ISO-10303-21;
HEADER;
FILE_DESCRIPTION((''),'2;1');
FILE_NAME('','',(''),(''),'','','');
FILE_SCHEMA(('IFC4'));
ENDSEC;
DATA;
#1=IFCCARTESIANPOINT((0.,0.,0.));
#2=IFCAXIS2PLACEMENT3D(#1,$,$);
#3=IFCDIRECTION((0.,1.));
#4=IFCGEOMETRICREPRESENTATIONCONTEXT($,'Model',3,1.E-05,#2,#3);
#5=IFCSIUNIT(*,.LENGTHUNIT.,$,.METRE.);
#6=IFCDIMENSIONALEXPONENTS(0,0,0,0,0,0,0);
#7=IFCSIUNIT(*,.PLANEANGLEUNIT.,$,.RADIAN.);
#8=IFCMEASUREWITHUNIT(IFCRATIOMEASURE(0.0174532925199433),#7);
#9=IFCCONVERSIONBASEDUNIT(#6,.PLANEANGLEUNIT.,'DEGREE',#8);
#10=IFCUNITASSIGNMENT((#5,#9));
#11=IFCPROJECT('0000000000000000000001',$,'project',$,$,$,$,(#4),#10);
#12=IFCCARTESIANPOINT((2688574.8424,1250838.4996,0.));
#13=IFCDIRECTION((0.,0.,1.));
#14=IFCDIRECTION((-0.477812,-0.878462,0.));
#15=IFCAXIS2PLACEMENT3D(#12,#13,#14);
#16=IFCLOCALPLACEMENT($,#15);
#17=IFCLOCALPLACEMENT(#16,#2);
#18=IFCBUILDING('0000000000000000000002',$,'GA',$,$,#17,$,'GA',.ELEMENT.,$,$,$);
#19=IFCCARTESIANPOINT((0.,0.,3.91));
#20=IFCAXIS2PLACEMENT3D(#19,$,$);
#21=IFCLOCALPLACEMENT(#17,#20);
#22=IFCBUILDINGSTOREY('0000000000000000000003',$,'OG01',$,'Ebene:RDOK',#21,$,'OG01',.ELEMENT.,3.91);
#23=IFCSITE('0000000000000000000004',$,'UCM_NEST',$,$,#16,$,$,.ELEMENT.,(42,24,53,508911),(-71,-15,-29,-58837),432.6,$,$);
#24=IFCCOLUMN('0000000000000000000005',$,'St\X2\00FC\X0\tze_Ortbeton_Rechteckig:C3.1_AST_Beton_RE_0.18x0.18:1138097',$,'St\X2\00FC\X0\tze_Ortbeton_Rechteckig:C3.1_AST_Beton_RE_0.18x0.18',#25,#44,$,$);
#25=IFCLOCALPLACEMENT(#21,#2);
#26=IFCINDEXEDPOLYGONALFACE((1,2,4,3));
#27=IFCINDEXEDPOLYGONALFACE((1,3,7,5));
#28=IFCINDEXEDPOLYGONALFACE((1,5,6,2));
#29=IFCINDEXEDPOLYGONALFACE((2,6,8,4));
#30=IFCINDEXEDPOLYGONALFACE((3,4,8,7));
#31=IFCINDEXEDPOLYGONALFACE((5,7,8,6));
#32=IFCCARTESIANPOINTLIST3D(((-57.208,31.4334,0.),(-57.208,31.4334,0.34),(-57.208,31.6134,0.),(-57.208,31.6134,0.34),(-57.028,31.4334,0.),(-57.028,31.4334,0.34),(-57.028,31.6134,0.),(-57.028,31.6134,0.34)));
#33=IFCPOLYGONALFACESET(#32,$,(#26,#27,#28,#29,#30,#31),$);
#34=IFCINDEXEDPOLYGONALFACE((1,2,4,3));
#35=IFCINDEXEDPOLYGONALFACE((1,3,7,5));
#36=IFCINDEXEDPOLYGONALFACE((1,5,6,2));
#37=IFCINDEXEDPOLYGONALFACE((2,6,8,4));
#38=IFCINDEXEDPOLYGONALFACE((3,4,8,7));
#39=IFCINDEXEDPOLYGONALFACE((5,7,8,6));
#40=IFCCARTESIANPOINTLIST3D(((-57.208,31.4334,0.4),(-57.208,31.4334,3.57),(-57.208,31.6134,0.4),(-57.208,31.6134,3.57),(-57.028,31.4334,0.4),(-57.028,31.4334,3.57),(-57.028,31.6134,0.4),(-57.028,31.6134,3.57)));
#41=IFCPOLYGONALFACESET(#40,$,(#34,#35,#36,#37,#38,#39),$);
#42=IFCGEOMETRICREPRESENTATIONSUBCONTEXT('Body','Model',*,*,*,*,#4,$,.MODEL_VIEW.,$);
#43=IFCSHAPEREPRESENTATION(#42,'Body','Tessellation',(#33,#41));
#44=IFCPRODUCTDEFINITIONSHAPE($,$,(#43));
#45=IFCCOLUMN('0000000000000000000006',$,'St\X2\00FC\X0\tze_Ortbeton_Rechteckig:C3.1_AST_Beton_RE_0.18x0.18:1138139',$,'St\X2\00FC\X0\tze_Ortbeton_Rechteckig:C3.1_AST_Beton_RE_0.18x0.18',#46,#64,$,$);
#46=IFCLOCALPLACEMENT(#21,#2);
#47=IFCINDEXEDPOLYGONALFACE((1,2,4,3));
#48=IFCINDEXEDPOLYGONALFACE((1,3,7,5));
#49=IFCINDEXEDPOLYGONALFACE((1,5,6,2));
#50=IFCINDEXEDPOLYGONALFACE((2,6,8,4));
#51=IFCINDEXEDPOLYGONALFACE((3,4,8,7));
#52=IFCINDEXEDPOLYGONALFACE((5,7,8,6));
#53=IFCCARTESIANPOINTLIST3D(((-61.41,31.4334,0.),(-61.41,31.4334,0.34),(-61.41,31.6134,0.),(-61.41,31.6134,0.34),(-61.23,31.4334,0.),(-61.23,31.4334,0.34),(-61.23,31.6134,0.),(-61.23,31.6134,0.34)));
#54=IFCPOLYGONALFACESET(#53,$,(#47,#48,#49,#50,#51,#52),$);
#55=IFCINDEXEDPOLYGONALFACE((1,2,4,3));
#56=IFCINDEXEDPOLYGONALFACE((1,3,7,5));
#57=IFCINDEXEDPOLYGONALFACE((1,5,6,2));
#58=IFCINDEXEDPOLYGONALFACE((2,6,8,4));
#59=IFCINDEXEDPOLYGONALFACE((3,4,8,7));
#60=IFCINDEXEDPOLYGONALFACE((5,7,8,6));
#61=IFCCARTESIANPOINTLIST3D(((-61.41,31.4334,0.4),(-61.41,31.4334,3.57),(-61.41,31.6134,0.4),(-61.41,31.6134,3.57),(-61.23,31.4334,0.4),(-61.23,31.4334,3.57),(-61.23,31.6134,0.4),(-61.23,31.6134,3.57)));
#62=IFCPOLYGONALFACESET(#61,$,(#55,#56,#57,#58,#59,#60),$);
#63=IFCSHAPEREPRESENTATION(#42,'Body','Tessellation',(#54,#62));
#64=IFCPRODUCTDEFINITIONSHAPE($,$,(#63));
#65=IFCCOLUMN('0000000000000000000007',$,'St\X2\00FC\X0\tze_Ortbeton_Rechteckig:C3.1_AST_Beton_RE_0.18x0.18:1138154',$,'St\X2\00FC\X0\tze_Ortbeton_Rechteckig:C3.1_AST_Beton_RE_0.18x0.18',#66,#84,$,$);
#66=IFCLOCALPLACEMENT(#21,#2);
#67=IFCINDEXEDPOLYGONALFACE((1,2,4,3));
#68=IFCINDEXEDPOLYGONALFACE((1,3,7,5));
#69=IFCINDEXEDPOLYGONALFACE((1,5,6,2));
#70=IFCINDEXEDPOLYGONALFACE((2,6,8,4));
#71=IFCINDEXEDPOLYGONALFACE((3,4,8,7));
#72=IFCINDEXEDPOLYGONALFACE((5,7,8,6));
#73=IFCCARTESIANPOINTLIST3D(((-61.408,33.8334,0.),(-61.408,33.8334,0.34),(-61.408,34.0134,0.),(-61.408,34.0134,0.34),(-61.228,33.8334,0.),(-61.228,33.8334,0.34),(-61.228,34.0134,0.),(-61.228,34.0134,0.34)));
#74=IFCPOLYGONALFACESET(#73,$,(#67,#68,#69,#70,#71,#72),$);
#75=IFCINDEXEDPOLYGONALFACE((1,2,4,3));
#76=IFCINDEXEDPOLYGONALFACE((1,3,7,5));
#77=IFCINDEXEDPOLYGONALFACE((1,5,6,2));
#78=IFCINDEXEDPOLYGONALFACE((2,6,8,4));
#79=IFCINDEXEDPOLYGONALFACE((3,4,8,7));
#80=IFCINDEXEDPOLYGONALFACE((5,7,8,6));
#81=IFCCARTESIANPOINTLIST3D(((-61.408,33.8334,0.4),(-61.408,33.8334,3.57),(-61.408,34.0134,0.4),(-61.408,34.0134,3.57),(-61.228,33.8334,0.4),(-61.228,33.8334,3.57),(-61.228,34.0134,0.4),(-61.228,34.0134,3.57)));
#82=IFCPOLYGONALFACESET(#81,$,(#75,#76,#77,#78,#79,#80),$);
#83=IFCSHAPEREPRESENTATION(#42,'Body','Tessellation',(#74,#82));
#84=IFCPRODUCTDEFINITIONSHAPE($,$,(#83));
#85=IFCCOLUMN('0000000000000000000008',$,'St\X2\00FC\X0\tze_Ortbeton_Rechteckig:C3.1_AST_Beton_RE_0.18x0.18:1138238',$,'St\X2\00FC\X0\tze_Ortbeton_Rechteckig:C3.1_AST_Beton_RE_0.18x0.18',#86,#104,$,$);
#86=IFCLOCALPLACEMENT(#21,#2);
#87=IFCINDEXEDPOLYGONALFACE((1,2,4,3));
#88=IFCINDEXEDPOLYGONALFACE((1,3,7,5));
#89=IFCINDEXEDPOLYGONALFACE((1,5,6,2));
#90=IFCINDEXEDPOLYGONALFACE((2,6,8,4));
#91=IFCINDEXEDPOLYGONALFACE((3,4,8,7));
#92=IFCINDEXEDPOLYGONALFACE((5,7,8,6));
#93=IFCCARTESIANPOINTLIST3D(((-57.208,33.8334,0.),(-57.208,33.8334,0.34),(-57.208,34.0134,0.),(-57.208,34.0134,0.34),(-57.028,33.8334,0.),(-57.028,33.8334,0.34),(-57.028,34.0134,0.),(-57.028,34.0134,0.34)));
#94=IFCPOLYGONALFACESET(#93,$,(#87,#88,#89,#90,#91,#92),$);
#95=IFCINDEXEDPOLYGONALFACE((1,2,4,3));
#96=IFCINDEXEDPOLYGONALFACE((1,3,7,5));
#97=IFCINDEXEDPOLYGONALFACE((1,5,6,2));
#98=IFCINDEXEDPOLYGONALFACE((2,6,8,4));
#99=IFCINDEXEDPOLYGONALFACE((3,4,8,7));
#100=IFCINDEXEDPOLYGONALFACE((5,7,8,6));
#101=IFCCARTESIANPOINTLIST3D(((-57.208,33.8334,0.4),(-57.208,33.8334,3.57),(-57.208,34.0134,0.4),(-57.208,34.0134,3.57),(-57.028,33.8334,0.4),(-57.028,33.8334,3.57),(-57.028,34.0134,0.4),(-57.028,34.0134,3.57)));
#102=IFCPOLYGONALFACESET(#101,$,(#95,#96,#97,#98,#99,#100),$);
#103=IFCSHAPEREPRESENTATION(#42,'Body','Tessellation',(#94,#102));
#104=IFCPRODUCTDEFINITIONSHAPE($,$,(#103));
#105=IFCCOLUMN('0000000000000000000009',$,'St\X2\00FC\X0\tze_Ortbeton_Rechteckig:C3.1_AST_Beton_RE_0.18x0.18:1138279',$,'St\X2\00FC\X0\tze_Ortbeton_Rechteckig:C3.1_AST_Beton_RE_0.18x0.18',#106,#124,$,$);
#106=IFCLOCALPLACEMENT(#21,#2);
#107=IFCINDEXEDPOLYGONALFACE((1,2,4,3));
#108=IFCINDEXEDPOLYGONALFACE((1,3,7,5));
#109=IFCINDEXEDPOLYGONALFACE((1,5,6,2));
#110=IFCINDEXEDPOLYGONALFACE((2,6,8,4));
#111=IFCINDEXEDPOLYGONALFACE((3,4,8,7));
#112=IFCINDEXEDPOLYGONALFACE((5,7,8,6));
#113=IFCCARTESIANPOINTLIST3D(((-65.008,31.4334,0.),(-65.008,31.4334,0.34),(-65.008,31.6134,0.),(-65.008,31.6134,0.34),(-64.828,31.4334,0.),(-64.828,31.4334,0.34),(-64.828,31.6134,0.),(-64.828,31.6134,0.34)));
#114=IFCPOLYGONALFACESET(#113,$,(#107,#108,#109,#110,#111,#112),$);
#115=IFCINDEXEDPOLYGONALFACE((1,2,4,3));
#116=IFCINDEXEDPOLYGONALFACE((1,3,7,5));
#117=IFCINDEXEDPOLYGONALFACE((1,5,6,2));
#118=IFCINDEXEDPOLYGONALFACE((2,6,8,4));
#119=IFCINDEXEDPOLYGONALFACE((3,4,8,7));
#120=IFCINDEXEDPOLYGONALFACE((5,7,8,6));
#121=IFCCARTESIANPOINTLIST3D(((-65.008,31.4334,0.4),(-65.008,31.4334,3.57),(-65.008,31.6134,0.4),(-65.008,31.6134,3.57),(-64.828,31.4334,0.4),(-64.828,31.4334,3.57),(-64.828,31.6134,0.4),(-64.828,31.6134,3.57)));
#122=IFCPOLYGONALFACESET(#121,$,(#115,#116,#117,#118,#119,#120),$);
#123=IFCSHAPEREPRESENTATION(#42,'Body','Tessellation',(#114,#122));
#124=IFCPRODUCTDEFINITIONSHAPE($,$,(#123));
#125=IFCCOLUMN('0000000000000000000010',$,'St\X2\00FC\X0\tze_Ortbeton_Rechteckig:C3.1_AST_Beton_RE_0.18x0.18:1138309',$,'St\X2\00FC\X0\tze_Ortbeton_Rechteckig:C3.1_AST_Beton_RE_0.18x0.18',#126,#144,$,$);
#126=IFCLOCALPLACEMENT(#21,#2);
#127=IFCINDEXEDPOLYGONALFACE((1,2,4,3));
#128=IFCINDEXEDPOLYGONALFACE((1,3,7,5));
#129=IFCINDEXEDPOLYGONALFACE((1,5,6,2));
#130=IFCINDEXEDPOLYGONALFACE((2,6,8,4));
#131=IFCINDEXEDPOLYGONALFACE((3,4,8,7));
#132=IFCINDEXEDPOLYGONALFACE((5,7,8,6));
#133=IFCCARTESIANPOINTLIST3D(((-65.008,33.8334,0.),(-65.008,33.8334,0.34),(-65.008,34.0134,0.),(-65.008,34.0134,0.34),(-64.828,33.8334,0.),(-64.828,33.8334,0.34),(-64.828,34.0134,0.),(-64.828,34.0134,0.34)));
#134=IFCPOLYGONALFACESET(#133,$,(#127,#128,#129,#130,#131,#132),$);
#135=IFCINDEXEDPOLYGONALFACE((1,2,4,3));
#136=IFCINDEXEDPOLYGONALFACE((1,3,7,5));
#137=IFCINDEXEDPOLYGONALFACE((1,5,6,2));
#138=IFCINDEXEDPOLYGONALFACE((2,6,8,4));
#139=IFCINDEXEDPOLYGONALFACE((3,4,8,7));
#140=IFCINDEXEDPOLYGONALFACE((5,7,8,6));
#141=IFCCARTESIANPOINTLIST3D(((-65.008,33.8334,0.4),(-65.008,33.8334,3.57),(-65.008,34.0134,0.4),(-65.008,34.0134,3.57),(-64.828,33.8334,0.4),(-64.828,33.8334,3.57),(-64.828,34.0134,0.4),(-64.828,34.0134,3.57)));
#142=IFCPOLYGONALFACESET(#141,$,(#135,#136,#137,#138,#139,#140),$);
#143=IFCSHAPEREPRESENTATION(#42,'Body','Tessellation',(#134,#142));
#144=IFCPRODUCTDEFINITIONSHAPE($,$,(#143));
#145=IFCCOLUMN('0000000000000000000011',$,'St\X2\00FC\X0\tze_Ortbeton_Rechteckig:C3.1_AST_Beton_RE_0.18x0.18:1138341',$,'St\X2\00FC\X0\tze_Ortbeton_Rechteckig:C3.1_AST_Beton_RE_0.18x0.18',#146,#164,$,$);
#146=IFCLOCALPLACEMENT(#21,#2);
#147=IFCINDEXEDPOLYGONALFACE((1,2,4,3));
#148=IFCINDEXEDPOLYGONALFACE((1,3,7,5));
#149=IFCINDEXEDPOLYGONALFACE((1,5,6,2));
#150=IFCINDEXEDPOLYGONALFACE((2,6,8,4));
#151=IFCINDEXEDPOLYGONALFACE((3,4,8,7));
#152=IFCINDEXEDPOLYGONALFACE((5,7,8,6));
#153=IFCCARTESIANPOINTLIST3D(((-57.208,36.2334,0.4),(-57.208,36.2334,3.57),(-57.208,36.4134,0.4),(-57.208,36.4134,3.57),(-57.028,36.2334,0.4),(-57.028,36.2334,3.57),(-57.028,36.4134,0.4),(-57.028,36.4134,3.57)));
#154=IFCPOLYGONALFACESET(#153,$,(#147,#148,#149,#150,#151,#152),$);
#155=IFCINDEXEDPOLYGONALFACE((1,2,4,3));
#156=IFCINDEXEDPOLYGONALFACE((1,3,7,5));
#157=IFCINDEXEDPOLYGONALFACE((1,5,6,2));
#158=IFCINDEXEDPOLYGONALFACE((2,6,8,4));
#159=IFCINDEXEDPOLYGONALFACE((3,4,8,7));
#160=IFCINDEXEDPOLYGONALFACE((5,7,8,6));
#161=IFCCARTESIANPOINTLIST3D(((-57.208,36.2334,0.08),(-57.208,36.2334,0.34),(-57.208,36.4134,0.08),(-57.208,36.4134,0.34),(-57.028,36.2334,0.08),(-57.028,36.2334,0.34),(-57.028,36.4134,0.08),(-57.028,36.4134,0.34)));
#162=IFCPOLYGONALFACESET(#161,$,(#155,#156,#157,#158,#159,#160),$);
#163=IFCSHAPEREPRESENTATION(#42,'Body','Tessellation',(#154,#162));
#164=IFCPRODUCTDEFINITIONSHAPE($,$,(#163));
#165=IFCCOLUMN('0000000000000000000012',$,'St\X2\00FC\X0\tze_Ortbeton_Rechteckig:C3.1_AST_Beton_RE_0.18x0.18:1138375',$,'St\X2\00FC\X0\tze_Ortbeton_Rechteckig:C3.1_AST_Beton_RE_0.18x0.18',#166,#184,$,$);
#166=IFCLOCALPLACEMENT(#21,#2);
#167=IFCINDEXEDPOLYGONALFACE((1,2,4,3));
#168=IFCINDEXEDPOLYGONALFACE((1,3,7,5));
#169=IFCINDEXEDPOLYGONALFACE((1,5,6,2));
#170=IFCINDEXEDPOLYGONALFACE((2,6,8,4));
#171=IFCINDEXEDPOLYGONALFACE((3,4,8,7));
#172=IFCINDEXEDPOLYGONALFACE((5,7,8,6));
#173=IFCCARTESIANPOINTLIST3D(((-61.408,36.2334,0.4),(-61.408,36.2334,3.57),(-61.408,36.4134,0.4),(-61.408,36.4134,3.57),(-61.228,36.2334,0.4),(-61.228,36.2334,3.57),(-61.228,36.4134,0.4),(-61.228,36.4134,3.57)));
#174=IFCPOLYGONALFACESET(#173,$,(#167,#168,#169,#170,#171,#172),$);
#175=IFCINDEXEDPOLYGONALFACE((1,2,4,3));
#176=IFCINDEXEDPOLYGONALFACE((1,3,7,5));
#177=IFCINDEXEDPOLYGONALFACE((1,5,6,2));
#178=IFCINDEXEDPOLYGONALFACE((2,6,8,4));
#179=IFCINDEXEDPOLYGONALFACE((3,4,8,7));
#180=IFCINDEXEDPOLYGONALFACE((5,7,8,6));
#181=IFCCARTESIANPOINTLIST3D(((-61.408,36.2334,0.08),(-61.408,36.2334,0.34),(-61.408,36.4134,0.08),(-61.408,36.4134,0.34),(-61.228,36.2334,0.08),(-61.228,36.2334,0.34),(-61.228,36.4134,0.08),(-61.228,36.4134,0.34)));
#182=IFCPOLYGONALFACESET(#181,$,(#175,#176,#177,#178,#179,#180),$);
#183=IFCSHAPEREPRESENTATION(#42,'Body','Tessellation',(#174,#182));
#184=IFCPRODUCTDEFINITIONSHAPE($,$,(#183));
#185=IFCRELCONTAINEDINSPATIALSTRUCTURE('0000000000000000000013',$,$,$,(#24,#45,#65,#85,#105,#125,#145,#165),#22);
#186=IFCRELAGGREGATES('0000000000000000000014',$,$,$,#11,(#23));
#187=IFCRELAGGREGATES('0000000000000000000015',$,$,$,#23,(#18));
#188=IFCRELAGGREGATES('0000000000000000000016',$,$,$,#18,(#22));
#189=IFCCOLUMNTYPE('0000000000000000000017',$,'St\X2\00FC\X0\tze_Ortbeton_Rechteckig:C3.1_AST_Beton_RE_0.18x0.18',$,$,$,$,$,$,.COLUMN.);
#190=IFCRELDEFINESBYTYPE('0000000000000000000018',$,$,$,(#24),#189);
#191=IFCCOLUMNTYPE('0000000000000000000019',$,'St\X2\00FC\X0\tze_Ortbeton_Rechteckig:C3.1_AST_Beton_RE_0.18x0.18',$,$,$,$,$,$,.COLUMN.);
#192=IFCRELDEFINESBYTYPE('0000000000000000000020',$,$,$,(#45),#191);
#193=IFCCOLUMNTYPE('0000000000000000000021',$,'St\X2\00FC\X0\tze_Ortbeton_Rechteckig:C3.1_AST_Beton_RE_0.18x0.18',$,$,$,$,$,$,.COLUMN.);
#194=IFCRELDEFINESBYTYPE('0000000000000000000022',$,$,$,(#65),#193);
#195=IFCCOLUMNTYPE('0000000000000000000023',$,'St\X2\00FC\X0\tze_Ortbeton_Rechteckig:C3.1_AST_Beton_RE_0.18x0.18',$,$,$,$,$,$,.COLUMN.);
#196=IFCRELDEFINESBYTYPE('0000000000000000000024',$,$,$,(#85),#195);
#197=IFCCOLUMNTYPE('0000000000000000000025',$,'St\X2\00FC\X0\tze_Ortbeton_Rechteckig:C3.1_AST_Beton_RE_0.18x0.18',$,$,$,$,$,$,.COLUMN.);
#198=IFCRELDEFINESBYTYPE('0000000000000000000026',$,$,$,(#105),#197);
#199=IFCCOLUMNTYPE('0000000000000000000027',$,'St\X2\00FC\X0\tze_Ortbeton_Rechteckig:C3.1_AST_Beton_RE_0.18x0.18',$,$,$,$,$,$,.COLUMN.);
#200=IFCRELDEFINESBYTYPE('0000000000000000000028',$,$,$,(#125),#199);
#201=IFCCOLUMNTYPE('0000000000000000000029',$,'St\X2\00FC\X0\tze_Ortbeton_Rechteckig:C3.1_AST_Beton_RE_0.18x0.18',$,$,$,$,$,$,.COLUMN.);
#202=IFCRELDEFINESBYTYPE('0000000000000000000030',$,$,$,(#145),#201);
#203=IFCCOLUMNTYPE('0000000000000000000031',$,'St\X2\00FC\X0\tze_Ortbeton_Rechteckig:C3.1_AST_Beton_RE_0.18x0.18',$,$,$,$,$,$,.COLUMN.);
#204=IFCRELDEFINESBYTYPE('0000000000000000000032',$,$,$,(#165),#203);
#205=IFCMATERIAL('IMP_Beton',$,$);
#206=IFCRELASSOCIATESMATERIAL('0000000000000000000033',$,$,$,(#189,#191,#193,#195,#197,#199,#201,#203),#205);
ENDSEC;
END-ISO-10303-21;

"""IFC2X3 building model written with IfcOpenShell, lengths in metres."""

from ifc_helpers import new_model, entity, si_unit, converted_unit, direction, frame, frame_2d, origin, origin_2d_with_axis, place, context, subcontext, project, spatial, rectangle, extrude, source, transform, mapped, material, type_object, type_shapes, element, save


model = new_model("IFC2X3")

# Units and contexts
model_context = context("Model", 3, precision=1e-05, world=origin(), true_north=direction((0.0, 1.0)))
body_context = subcontext(model_context, "Body", "Model", "MODEL_VIEW")
ifc_project = project(units=[si_unit("LENGTHUNIT", "METRE"), converted_unit("PLANEANGLEUNIT", "DEGREE", entity("IfcRatioMeasure", 0.0174532925199433), si_unit("PLANEANGLEUNIT", "RADIAN"), dimensions=[0, 0, 0, 0, 0, 0, 0])], contexts=[model_context])

# Site, building, storey
site_placement = place(None, frame((2688574.8424, 1250838.4996, 0.0), z_axis=(0.0, 0.0, 1.0), x_axis=(-0.477812, -0.878462, 0.0)))
site = spatial("IfcSite", under=ifc_project, at=site_placement, Name="UCM_NEST", CompositionType="ELEMENT", RefLatitude=(42, 24, 53, 508911), RefLongitude=(-71, -15, -29, -58837), RefElevation=432.6)
building_placement = place(site_placement, origin())
building = spatial("IfcBuilding", under=site, at=building_placement, Name="GA", LongName="GA", CompositionType="ELEMENT")
storey_placement = place(building_placement, frame((0.0, 0.0, 3.91)))
storey = spatial("IfcBuildingStorey", under=building, at=storey_placement, Name="OG01", ObjectType="Ebene:RDOK", LongName="OG01", CompositionType="ELEMENT", Elevation=3.91)

# Columns
ifc_material_1 = material(Name="IMP_Beton")
column_type_1 = type_object("IfcColumnType", Name="Stütze_Ortbeton_Rechteckig:C3.1_AST_Beton_RE_0.18x0.18", PredefinedType="COLUMN", material=ifc_material_1)
shared_shape_1 = source(origin(), body_context, "Body", "SweptSolid", [
    extrude(rectangle(XDim=0.18, YDim=0.18, at=origin_2d_with_axis()), frame((-57.118, 31.5234, 3.91), z_axis=(0.0, 0.0, 1.0), x_axis=(0.0, -1.0, 0.0)), (0.0, 0.0, 1.0), 0.34),
    extrude(rectangle(XDim=0.18, YDim=0.18, at=origin_2d_with_axis()), frame((-57.118, 31.5234, 4.31), z_axis=(0.0, 0.0, 1.0), x_axis=(0.0, -1.0, 0.0)), (0.0, 0.0, 1.0), 3.17),
])
type_shapes(column_type_1, [shared_shape_1])
column_1_placement = place(storey_placement, frame((0.0, 0.0, -3.91)))
element("IfcColumn", 1, at=column_1_placement, inside=storey, type_object=column_type_1, Name="Stütze_Ortbeton_Rechteckig:C3.1_AST_Beton_RE_0.18x0.18:1138097", ObjectType="Stütze_Ortbeton_Rechteckig:C3.1_AST_Beton_RE_0.18x0.18", context=body_context, shape_type="MappedRepresentation", body=[
    mapped(shared_shape_1, transform((0.0, 0.0, 0.0), scale=1.0)),
])
column_type_2 = type_object("IfcColumnType", Name="Stütze_Ortbeton_Rechteckig:C3.1_AST_Beton_RE_0.18x0.18", PredefinedType="COLUMN", material=ifc_material_1)
shared_shape_2 = source(origin(), body_context, "Body", "SweptSolid", [
    extrude(rectangle(XDim=0.18, YDim=0.18, at=origin_2d_with_axis()), frame((-61.32, 31.5234, 3.91), z_axis=(0.0, 0.0, 1.0), x_axis=(0.0, -1.0, 0.0)), (0.0, 0.0, 1.0), 0.34),
    extrude(rectangle(XDim=0.18, YDim=0.18, at=origin_2d_with_axis()), frame((-61.32, 31.5234, 4.31), z_axis=(0.0, 0.0, 1.0), x_axis=(0.0, -1.0, 0.0)), (0.0, 0.0, 1.0), 3.17),
])
type_shapes(column_type_2, [shared_shape_2])
column_2_placement = place(storey_placement, frame((0.0, 0.0, -3.91)))
element("IfcColumn", 2, at=column_2_placement, inside=storey, type_object=column_type_2, Name="Stütze_Ortbeton_Rechteckig:C3.1_AST_Beton_RE_0.18x0.18:1138139", ObjectType="Stütze_Ortbeton_Rechteckig:C3.1_AST_Beton_RE_0.18x0.18", context=body_context, shape_type="MappedRepresentation", body=[
    mapped(shared_shape_2, transform((0.0, 0.0, 0.0), scale=1.0)),
])
column_type_3 = type_object("IfcColumnType", Name="Stütze_Ortbeton_Rechteckig:C3.1_AST_Beton_RE_0.18x0.18", PredefinedType="COLUMN", material=ifc_material_1)
shared_shape_3 = source(origin(), body_context, "Body", "SweptSolid", [
    extrude(rectangle(XDim=0.18, YDim=0.18, at=origin_2d_with_axis()), frame((-61.318, 33.9234, 3.91), z_axis=(0.0, 0.0, 1.0), x_axis=(0.0, -1.0, 0.0)), (0.0, 0.0, 1.0), 0.34),
    extrude(rectangle(XDim=0.18, YDim=0.18, at=origin_2d_with_axis()), frame((-61.318, 33.9234, 4.31), z_axis=(0.0, 0.0, 1.0), x_axis=(0.0, -1.0, 0.0)), (0.0, 0.0, 1.0), 3.17),
])
type_shapes(column_type_3, [shared_shape_3])
column_3_placement = place(storey_placement, frame((0.0, 0.0, -3.91)))
element("IfcColumn", 3, at=column_3_placement, inside=storey, type_object=column_type_3, Name="Stütze_Ortbeton_Rechteckig:C3.1_AST_Beton_RE_0.18x0.18:1138154", ObjectType="Stütze_Ortbeton_Rechteckig:C3.1_AST_Beton_RE_0.18x0.18", context=body_context, shape_type="MappedRepresentation", body=[
    mapped(shared_shape_3, transform((0.0, 0.0, 0.0), scale=1.0)),
])
column_type_4 = type_object("IfcColumnType", Name="Stütze_Ortbeton_Rechteckig:C3.1_AST_Beton_RE_0.18x0.18", PredefinedType="COLUMN", material=ifc_material_1)
shared_shape_4 = source(origin(), body_context, "Body", "SweptSolid", [
    extrude(rectangle(XDim=0.18, YDim=0.18, at=origin_2d_with_axis()), frame((-57.118, 33.9234, 3.91), z_axis=(0.0, 0.0, 1.0), x_axis=(0.0, -1.0, 0.0)), (0.0, 0.0, 1.0), 0.34),
    extrude(rectangle(XDim=0.18, YDim=0.18, at=origin_2d_with_axis()), frame((-57.118, 33.9234, 4.31), z_axis=(0.0, 0.0, 1.0), x_axis=(0.0, -1.0, 0.0)), (0.0, 0.0, 1.0), 3.17),
])
type_shapes(column_type_4, [shared_shape_4])
column_4_placement = place(storey_placement, frame((0.0, 0.0, -3.91)))
element("IfcColumn", 4, at=column_4_placement, inside=storey, type_object=column_type_4, Name="Stütze_Ortbeton_Rechteckig:C3.1_AST_Beton_RE_0.18x0.18:1138238", ObjectType="Stütze_Ortbeton_Rechteckig:C3.1_AST_Beton_RE_0.18x0.18", context=body_context, shape_type="MappedRepresentation", body=[
    mapped(shared_shape_4, transform((0.0, 0.0, 0.0), scale=1.0)),
])
column_type_5 = type_object("IfcColumnType", Name="Stütze_Ortbeton_Rechteckig:C3.1_AST_Beton_RE_0.18x0.18", PredefinedType="COLUMN", material=ifc_material_1)
shared_shape_5 = source(origin(), body_context, "Body", "SweptSolid", [
    extrude(rectangle(XDim=0.18, YDim=0.18, at=origin_2d_with_axis()), frame((-64.918, 31.5234, 3.91), z_axis=(0.0, 0.0, 1.0), x_axis=(0.0, -1.0, 0.0)), (0.0, 0.0, 1.0), 0.34),
    extrude(rectangle(XDim=0.18, YDim=0.18, at=origin_2d_with_axis()), frame((-64.918, 31.5234, 4.31), z_axis=(0.0, 0.0, 1.0), x_axis=(0.0, -1.0, 0.0)), (0.0, 0.0, 1.0), 3.17),
])
type_shapes(column_type_5, [shared_shape_5])
column_5_placement = place(storey_placement, frame((0.0, 0.0, -3.91)))
element("IfcColumn", 5, at=column_5_placement, inside=storey, type_object=column_type_5, Name="Stütze_Ortbeton_Rechteckig:C3.1_AST_Beton_RE_0.18x0.18:1138279", ObjectType="Stütze_Ortbeton_Rechteckig:C3.1_AST_Beton_RE_0.18x0.18", context=body_context, shape_type="MappedRepresentation", body=[
    mapped(shared_shape_5, transform((0.0, 0.0, 0.0), scale=1.0)),
])
column_type_6 = type_object("IfcColumnType", Name="Stütze_Ortbeton_Rechteckig:C3.1_AST_Beton_RE_0.18x0.18", PredefinedType="COLUMN", material=ifc_material_1)
shared_shape_6 = source(origin(), body_context, "Body", "SweptSolid", [
    extrude(rectangle(XDim=0.18, YDim=0.18, at=frame_2d((0.0, 0.0), x_axis=(1.0, 0.0))), frame((-64.918, 33.9234, 3.91), z_axis=(0.0, 0.0, 1.0), x_axis=(0.0, -1.0, 0.0)), (0.0, 0.0, 1.0), 0.34),
    extrude(rectangle(XDim=0.18, YDim=0.18, at=frame_2d((0.0, 0.0), x_axis=(1.0, 0.0))), frame((-64.918, 33.9234, 4.31), z_axis=(0.0, 0.0, 1.0), x_axis=(0.0, -1.0, 0.0)), (0.0, 0.0, 1.0), 3.17),
])
type_shapes(column_type_6, [shared_shape_6])
column_6_placement = place(storey_placement, frame((0.0, 0.0, -3.91)))
element("IfcColumn", 6, at=column_6_placement, inside=storey, type_object=column_type_6, Name="Stütze_Ortbeton_Rechteckig:C3.1_AST_Beton_RE_0.18x0.18:1138309", ObjectType="Stütze_Ortbeton_Rechteckig:C3.1_AST_Beton_RE_0.18x0.18", context=body_context, shape_type="MappedRepresentation", body=[
    mapped(shared_shape_6, transform((0.0, 0.0, 0.0), scale=1.0)),
])
column_type_7 = type_object("IfcColumnType", Name="Stütze_Ortbeton_Rechteckig:C3.1_AST_Beton_RE_0.18x0.18", PredefinedType="COLUMN", material=ifc_material_1)
shared_shape_7 = source(origin(), body_context, "Body", "SweptSolid", [
    extrude(rectangle(XDim=0.18, YDim=0.18, at=origin_2d_with_axis()), frame((-57.118, 36.3234, 4.31), z_axis=(0.0, 0.0, 1.0), x_axis=(0.0, -1.0, 0.0)), (0.0, 0.0, 1.0), 3.17),
    extrude(rectangle(XDim=0.18, YDim=0.18, at=origin_2d_with_axis()), frame((-57.118, 36.3234, 3.99), z_axis=(0.0, 0.0, 1.0), x_axis=(0.0, -1.0, 0.0)), (0.0, 0.0, 1.0), 0.26),
])
type_shapes(column_type_7, [shared_shape_7])
column_7_placement = place(storey_placement, frame((0.0, 0.0, -3.91)))
element("IfcColumn", 7, at=column_7_placement, inside=storey, type_object=column_type_7, Name="Stütze_Ortbeton_Rechteckig:C3.1_AST_Beton_RE_0.18x0.18:1138341", ObjectType="Stütze_Ortbeton_Rechteckig:C3.1_AST_Beton_RE_0.18x0.18", context=body_context, shape_type="MappedRepresentation", body=[
    mapped(shared_shape_7, transform((0.0, 0.0, 0.0), scale=1.0)),
])
column_type_8 = type_object("IfcColumnType", Name="Stütze_Ortbeton_Rechteckig:C3.1_AST_Beton_RE_0.18x0.18", PredefinedType="COLUMN", material=ifc_material_1)
shared_shape_8 = source(origin(), body_context, "Body", "SweptSolid", [
    extrude(rectangle(XDim=0.18, YDim=0.18, at=origin_2d_with_axis()), frame((-61.318, 36.3234, 4.31), z_axis=(0.0, 0.0, 1.0), x_axis=(0.0, -1.0, 0.0)), (0.0, 0.0, 1.0), 3.17),
    extrude(rectangle(XDim=0.18, YDim=0.18, at=origin_2d_with_axis()), frame((-61.318, 36.3234, 3.99), z_axis=(0.0, 0.0, 1.0), x_axis=(0.0, -1.0, 0.0)), (0.0, 0.0, 1.0), 0.26),
])
type_shapes(column_type_8, [shared_shape_8])
column_8_placement = place(storey_placement, frame((0.0, 0.0, -3.91)))
element("IfcColumn", 8, at=column_8_placement, inside=storey, type_object=column_type_8, Name="Stütze_Ortbeton_Rechteckig:C3.1_AST_Beton_RE_0.18x0.18:1138375", ObjectType="Stütze_Ortbeton_Rechteckig:C3.1_AST_Beton_RE_0.18x0.18", context=body_context, shape_type="MappedRepresentation", body=[
    mapped(shared_shape_8, transform((0.0, 0.0, 0.0), scale=1.0)),
])

save(model, "model.ifc")
